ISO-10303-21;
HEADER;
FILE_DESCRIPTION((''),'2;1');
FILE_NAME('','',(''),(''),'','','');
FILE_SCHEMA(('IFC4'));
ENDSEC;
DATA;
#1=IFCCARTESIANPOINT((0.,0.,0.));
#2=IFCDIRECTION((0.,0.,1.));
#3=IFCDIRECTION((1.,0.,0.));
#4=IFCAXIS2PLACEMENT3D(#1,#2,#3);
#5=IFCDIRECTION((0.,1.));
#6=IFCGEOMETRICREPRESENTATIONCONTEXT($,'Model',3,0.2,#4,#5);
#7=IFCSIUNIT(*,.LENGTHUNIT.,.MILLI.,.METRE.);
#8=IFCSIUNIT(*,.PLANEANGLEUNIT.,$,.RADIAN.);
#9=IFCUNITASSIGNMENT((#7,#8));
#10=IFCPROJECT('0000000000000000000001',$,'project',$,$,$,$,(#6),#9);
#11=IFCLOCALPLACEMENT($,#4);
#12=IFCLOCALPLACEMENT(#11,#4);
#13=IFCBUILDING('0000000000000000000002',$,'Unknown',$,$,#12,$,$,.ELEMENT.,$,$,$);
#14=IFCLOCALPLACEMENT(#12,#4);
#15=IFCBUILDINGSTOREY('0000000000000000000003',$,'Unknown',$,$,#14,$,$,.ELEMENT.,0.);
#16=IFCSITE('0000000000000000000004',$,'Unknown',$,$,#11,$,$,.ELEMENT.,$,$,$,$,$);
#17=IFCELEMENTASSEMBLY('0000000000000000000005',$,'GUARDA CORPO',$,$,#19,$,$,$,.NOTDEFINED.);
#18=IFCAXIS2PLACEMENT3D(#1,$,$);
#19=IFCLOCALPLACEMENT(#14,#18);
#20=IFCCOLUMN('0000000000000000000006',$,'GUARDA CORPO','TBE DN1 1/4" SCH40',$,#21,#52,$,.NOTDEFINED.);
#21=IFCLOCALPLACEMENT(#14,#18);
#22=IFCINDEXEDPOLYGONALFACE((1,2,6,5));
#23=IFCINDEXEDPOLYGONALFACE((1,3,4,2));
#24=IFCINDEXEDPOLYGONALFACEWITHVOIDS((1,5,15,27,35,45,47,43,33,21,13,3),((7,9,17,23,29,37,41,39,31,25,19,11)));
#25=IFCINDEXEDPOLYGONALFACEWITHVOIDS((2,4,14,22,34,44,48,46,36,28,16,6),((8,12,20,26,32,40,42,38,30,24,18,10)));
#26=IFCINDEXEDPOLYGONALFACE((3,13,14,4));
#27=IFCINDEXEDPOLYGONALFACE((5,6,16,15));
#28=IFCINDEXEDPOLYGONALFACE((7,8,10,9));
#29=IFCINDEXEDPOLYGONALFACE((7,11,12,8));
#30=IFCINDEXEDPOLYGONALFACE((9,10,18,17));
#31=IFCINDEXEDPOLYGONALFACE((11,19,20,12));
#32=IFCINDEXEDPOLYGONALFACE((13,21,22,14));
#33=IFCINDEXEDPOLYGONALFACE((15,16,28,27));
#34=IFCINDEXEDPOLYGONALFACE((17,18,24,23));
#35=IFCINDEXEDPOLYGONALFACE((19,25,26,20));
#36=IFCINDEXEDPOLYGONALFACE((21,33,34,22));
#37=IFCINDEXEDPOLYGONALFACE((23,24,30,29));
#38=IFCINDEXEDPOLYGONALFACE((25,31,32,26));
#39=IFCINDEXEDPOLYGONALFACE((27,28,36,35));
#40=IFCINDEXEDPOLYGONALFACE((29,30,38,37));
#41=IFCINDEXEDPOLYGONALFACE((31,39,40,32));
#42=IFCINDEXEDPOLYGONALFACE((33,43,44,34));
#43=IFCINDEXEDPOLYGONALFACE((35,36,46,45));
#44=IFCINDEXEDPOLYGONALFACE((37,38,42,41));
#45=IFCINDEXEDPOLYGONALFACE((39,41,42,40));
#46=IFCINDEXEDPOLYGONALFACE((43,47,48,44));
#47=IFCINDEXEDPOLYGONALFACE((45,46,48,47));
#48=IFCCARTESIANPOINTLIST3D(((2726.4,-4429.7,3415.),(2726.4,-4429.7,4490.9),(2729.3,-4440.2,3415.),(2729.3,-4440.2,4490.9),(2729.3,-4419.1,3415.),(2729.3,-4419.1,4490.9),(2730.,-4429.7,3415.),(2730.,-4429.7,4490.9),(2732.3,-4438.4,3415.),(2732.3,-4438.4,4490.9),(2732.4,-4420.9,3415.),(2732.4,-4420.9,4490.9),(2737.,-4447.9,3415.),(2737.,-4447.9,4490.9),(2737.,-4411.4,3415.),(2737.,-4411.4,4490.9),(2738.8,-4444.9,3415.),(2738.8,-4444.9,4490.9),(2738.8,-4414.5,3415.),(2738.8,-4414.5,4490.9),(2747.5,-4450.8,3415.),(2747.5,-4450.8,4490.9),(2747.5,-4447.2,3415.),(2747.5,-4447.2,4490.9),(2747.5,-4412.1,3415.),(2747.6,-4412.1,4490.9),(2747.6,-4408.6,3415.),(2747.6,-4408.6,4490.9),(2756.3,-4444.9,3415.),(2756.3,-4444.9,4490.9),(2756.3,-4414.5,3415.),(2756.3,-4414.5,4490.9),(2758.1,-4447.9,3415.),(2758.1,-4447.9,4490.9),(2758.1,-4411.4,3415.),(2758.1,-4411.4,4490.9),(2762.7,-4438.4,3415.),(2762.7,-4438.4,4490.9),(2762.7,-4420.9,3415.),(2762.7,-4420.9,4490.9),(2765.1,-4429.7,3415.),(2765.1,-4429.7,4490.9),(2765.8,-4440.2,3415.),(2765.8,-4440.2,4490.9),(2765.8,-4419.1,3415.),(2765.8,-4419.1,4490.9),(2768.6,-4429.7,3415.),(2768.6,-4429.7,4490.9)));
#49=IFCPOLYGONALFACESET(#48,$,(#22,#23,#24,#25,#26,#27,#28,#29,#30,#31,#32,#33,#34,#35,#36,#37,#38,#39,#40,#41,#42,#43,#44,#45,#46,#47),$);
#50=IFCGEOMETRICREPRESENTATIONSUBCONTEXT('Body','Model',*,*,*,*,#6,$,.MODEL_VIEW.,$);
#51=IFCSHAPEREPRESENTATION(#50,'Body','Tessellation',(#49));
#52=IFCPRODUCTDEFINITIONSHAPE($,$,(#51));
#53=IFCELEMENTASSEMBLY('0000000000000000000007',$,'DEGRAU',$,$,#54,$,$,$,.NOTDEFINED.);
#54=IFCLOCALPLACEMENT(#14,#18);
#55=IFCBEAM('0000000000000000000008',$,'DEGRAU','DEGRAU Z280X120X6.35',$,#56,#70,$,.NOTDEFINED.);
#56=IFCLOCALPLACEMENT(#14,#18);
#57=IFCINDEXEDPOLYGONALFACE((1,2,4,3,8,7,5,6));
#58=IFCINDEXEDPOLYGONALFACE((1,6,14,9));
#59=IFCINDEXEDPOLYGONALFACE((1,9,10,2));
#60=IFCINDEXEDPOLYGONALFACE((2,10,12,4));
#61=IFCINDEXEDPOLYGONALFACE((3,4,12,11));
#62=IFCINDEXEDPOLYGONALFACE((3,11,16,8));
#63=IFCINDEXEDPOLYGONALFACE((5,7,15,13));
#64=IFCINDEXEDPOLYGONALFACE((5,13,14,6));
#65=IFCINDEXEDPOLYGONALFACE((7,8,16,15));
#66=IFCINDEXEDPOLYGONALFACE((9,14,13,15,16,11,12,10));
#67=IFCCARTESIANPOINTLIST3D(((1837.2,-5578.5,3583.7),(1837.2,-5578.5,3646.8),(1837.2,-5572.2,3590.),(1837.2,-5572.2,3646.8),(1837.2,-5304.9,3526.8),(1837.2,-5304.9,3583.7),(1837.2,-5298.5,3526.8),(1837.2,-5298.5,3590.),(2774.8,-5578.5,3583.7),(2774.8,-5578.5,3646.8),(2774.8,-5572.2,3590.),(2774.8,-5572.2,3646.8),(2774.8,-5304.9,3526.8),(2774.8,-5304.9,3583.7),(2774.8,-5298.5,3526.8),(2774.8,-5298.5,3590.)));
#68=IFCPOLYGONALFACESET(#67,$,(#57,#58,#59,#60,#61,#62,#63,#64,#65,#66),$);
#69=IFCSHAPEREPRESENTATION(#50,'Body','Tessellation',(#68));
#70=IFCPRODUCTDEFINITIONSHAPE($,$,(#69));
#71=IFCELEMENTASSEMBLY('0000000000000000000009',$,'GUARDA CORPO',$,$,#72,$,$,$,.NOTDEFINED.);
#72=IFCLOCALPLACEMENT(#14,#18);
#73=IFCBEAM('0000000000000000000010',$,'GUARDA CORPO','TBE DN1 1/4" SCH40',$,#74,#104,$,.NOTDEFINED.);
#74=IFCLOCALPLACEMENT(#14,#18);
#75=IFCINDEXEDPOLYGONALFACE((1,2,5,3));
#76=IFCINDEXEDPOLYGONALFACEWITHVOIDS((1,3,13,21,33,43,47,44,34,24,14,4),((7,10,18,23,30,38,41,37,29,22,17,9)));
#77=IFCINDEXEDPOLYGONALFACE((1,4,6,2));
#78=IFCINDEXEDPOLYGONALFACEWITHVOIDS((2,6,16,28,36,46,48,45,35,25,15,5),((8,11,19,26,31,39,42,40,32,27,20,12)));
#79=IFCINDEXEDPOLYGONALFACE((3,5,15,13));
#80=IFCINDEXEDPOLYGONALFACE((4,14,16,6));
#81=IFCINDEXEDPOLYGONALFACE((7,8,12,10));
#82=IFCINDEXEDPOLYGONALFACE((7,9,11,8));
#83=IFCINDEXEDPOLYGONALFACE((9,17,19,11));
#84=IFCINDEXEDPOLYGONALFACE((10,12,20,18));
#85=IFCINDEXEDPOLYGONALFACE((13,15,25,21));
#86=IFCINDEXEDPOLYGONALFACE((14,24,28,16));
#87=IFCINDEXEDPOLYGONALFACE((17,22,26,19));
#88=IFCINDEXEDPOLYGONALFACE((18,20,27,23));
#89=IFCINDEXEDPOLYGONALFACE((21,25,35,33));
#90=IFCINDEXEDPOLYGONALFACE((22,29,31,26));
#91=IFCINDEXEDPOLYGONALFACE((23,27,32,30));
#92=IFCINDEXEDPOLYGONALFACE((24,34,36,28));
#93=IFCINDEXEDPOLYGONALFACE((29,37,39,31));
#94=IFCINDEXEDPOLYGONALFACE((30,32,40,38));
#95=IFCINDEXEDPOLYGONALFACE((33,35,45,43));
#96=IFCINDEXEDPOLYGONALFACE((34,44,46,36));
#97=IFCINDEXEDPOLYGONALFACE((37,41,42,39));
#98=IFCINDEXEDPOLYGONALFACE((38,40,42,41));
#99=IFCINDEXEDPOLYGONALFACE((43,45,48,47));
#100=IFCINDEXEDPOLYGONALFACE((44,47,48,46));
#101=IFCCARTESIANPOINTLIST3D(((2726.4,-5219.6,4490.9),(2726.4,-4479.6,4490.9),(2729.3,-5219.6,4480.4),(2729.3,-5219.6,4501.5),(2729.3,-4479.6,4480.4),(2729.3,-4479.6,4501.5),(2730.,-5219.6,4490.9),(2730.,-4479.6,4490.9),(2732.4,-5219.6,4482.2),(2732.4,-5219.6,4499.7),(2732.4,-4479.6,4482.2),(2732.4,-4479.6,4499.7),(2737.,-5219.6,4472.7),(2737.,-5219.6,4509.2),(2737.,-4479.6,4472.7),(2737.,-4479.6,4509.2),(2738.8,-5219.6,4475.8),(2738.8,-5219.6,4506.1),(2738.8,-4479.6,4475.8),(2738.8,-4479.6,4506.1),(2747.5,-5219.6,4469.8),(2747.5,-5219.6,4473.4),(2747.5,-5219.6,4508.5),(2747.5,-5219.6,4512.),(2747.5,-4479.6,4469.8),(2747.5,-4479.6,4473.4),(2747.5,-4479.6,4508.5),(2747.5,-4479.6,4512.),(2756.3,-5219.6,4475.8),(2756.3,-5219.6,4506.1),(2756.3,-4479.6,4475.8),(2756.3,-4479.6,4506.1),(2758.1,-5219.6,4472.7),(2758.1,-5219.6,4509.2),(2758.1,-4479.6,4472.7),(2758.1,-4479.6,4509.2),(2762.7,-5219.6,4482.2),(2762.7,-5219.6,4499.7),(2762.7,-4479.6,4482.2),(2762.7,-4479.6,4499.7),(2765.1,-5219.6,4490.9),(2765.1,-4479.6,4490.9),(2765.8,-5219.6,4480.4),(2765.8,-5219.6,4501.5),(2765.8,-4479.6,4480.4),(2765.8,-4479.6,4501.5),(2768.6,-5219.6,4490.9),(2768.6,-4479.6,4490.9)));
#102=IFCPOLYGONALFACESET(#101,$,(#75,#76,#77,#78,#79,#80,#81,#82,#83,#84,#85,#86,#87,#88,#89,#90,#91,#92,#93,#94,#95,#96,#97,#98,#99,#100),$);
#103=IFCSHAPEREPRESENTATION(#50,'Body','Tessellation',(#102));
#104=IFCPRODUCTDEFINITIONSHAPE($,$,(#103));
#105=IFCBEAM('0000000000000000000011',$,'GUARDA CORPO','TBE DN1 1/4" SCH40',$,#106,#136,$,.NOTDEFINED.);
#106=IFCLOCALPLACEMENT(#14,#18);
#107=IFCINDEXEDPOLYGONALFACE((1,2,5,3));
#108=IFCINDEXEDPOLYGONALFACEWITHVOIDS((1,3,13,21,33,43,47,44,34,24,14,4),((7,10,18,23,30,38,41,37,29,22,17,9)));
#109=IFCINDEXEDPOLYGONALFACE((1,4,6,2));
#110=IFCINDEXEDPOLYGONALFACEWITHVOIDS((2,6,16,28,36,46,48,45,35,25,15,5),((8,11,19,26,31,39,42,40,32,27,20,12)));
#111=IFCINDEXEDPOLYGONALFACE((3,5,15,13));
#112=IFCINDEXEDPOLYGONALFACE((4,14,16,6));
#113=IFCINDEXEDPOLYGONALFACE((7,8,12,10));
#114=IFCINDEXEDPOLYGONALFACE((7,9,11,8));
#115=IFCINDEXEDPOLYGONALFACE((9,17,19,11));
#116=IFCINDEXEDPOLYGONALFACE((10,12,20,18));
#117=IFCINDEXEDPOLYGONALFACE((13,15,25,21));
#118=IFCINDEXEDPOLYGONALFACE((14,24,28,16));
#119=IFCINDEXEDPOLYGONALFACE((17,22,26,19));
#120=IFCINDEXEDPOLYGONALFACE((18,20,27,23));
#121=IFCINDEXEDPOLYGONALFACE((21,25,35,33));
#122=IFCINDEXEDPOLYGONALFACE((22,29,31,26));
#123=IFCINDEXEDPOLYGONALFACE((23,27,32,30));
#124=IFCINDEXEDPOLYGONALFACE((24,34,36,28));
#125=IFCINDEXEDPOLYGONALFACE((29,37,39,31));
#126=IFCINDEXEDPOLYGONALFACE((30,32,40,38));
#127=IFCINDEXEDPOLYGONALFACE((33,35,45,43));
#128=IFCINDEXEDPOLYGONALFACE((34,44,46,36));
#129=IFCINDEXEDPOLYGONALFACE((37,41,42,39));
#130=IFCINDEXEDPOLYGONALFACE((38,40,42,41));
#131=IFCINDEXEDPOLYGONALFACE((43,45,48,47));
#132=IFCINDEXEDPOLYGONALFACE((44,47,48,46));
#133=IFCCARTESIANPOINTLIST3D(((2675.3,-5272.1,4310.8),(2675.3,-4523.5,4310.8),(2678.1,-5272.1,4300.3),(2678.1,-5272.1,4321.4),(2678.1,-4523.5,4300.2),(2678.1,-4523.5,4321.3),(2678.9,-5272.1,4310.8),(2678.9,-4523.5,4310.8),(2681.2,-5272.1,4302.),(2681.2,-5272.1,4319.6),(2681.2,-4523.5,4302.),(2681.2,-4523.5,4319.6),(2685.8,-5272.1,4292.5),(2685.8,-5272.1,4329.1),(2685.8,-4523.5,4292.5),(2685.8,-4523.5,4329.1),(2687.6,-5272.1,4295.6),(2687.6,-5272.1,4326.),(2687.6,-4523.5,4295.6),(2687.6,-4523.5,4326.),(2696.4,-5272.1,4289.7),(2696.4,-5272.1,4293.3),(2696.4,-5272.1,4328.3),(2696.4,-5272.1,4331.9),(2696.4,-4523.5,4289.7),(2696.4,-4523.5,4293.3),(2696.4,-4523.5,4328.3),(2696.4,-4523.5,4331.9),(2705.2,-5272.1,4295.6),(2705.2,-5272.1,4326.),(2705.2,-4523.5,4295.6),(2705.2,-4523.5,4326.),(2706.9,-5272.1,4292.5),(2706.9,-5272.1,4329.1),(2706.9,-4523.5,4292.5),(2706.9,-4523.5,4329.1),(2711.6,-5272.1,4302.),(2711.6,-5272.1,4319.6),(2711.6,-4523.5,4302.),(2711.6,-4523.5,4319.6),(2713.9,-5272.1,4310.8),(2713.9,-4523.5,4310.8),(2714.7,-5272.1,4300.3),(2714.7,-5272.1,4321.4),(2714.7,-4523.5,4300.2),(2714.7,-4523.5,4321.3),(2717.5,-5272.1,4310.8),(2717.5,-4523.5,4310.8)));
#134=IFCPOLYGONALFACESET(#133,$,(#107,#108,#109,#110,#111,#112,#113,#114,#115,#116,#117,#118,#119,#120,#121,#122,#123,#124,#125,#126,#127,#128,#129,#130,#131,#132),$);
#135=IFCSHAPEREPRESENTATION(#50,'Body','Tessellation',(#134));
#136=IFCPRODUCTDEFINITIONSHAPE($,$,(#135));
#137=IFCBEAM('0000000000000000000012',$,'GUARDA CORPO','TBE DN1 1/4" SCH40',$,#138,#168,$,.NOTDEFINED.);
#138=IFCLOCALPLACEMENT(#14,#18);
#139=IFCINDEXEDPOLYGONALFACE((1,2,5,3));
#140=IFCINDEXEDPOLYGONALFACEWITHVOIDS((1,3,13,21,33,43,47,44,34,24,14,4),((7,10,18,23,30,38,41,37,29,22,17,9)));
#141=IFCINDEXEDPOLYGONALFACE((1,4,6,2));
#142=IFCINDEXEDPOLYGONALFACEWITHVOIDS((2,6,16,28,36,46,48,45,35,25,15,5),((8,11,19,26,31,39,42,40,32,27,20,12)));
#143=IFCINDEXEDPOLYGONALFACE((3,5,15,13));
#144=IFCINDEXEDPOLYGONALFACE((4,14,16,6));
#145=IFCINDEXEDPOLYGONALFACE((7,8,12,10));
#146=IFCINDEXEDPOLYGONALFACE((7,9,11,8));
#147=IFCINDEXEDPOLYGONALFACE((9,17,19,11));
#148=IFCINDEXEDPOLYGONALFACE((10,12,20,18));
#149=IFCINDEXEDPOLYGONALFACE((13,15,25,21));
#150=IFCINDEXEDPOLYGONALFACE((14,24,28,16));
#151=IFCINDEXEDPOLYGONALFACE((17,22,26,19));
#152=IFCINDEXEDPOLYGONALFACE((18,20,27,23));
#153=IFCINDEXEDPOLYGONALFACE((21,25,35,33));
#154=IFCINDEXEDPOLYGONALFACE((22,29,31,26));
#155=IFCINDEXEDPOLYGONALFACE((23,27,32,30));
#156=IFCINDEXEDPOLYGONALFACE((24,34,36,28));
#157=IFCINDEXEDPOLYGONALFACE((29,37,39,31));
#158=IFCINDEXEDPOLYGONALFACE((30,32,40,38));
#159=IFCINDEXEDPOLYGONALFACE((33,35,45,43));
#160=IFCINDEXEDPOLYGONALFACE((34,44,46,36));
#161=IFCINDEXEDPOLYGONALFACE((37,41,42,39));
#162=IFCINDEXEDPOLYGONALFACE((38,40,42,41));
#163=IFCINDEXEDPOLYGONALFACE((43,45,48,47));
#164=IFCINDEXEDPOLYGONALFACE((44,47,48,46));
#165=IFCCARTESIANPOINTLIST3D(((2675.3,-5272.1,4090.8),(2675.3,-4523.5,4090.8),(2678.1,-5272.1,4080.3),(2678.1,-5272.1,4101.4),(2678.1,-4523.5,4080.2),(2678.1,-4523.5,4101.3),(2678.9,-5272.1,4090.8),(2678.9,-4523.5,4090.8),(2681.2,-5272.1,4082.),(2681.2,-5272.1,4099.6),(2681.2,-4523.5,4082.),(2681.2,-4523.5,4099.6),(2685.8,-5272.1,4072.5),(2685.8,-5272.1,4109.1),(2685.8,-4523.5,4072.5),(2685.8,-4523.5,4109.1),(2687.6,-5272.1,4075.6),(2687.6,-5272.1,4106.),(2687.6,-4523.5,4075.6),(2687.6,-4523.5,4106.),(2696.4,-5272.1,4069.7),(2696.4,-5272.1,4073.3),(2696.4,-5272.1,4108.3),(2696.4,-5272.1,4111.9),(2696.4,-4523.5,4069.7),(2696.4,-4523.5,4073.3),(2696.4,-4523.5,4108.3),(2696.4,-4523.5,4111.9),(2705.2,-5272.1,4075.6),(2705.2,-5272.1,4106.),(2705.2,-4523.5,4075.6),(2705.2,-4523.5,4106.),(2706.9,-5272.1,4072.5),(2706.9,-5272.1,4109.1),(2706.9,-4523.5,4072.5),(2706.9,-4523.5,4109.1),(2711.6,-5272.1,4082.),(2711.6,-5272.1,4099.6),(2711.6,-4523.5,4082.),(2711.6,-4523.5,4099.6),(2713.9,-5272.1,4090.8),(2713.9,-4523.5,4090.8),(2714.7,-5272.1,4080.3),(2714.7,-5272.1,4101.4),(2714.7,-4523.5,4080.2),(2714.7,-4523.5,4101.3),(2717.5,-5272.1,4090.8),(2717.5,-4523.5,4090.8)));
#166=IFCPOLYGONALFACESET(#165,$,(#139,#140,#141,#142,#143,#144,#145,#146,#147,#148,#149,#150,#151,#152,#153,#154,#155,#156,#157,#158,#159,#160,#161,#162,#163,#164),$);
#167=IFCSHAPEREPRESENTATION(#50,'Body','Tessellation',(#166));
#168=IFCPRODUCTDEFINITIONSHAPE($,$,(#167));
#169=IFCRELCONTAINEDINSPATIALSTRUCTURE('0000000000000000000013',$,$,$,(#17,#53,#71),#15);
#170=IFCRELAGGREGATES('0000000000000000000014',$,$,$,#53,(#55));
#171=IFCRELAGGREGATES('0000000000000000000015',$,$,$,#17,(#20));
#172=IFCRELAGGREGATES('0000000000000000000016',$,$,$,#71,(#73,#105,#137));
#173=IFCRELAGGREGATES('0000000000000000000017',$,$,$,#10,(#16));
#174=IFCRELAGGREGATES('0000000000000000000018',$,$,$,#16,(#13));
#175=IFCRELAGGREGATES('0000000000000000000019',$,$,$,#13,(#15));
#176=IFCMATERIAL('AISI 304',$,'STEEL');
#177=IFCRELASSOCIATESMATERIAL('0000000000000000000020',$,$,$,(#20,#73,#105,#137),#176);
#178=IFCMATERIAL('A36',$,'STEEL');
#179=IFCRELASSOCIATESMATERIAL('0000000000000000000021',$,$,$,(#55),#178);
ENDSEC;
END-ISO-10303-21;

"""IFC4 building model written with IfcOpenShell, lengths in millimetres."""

from ifc_helpers import new_model, si_unit, direction, frame, origin_with_axes, place, context, subcontext, project, spatial, line, indexed_curve, outline, extrude, material, element, aggregate, save


model = new_model("IFC4")

# Units and contexts
model_context = context("Model", 3, precision=0.2, world=origin_with_axes(), true_north=direction((0.0, 1.0)))
body_context = subcontext(model_context, "Body", "Model", "MODEL_VIEW")
ifc_project = project(units=[si_unit("LENGTHUNIT", "METRE", prefix="MILLI"), si_unit("PLANEANGLEUNIT", "RADIAN")], contexts=[model_context])

# Site, building, storey
site_placement = place(None, origin_with_axes())
site = spatial("IfcSite", under=ifc_project, at=site_placement, Name="Unknown", CompositionType="ELEMENT")
building_placement = place(site_placement, origin_with_axes())
building = spatial("IfcBuilding", under=site, at=building_placement, Name="Unknown", CompositionType="ELEMENT")
storey_placement = place(building_placement, origin_with_axes())
storey = spatial("IfcBuildingStorey", under=building, at=storey_placement, Name="Unknown", CompositionType="ELEMENT", Elevation=0.0)

# Element assembly, column
assembly_1_placement = place(storey_placement, frame((2747.5, -4429.7, 3415.0), z_axis=(-0.000512, -1.0, -0.000003), x_axis=(0.000003, -0.000003, 1.0)))
assembly_1 = element("IfcElementAssembly", 1, at=assembly_1_placement, inside=storey, Name="GUARDA CORPO", PredefinedType="NOTDEFINED")
ifc_material_1 = material(Name="AISI 304", Category="STEEL")
column_placement = place(assembly_1_placement, origin_with_axes())
column = element("IfcColumn", 2, at=column_placement, material=ifc_material_1, Name="GUARDA CORPO", Description="TBE DN1 1/4\" SCH40", PredefinedType="NOTDEFINED", context=body_context, shape_type="SolidModel", body=[
    extrude(outline(indexed_curve([(21.1, 0.0), (18.3, 10.6), (10.6, 18.3), (0.0, 21.1), (-10.6, 18.3), (-18.3, 10.6), (-21.1, 0.0), (-18.3, -10.6), (-10.6, -18.3), (0.0, -21.1), (10.6, -18.3), (18.3, -10.6)], segments=[line(1, 2, 3, 4, 5, 6, 7, 8, 9, 10, 11, 12, 1)]), holes=[indexed_curve([(17.5, 0.0), (15.2, -8.8), (8.8, -15.2), (0.0, -17.5), (-8.8, -15.2), (-15.2, -8.8), (-17.5, 0.0), (-15.2, 8.8), (-8.8, 15.2), (0.0, 17.5), (8.8, 15.2), (15.2, 8.8)], segments=[line(1, 2, 3, 4, 5, 6, 7, 8, 9, 10, 11, 12, 1)])]), frame((0.0, 0.0, 0.0), z_axis=(-1.0, 0.0, 0.0), x_axis=(0.0, 0.0, 1.0)), (0.0, 0.0, -1.0), 1075.9),
])

# Shared definitions
ifc_material_2 = material(Name="A36", Category="STEEL")

# Element assembly, beam
assembly_2_placement = place(storey_placement, frame((1837.2, -5438.5, 3586.8), z_axis=(0.0, 0.0, 1.0), x_axis=(1.0, 0.0, 0.0)))
assembly_2 = element("IfcElementAssembly", 3, at=assembly_2_placement, inside=storey, Name="DEGRAU", PredefinedType="NOTDEFINED")
beam_1_placement = place(assembly_2_placement, origin_with_axes())
beam_1 = element("IfcBeam", 4, at=beam_1_placement, material=ifc_material_2, Name="DEGRAU", Description="DEGRAU Z280X120X6.35", PredefinedType="NOTDEFINED", context=body_context, shape_type="SolidModel", body=[
    extrude(outline(indexed_curve([(-3.2, -140.0), (60.0, -140.0), (60.0, -133.7), (3.2, -133.7), (3.2, 140.0), (-60.0, 140.0), (-60.0, 133.7), (-3.2, 133.7)], segments=[line(1, 2, 3, 4, 5, 6, 7, 8, 1)])), frame((0.0, 0.0, 0.0), z_axis=(-1.0, 0.0, 0.0), x_axis=(0.0, 0.0, 1.0)), (0.0, 0.0, -1.0), 937.5),
])
aggregate(assembly_2, [beam_1])

# Element assembly, beams
assembly_3_placement = place(storey_placement, frame((2747.5, -5087.8, 3415.0), z_axis=(-1.0, 0.000512, 0.000003), x_axis=(0.000003, 0.000003, 1.0)))
assembly_3 = element("IfcElementAssembly", 5, at=assembly_3_placement, inside=storey, Name="GUARDA CORPO", PredefinedType="NOTDEFINED")
beam_2_placement = place(assembly_3_placement, frame((1075.9, 608.1, 0.3), z_axis=(-0.000003, 0.000512, -1.0), x_axis=(0.000003, -1.0, -0.000512)))
beam_2 = element("IfcBeam", 6, at=beam_2_placement, material=ifc_material_1, Name="GUARDA CORPO", Description="TBE DN1 1/4\" SCH40", PredefinedType="NOTDEFINED", context=body_context, shape_type="SolidModel", body=[
    extrude(outline(indexed_curve([(21.1, 0.0), (18.3, 10.6), (10.6, 18.3), (0.0, 21.1), (-10.6, 18.3), (-18.3, 10.6), (-21.1, 0.0), (-18.3, -10.6), (-10.6, -18.3), (0.0, -21.1), (10.6, -18.3), (18.3, -10.6)], segments=[line(1, 2, 3, 4, 5, 6, 7, 8, 9, 10, 11, 12, 1)]), holes=[indexed_curve([(17.5, 0.0), (15.2, -8.8), (8.8, -15.2), (0.0, -17.5), (-8.8, -15.2), (-15.2, -8.8), (-17.5, 0.0), (-15.2, 8.8), (-8.8, 15.2), (0.0, 17.5), (8.8, 15.2), (15.2, 8.8)], segments=[line(1, 2, 3, 4, 5, 6, 7, 8, 9, 10, 11, 12, 1)])]), frame((0.0, 0.0, 0.0), z_axis=(-1.0, 0.0, 0.0), x_axis=(0.0, 0.0, 1.0)), (0.0, 0.0, -1.0), 740.0),
])
beam_3_placement = place(assembly_3_placement, frame((895.8, 564.2, 51.4), z_axis=(-0.000003, 0.000512, -1.0), x_axis=(0.000004, -1.0, -0.000512)))
beam_3 = element("IfcBeam", 7, at=beam_3_placement, material=ifc_material_1, Name="GUARDA CORPO", Description="TBE DN1 1/4\" SCH40", PredefinedType="NOTDEFINED", context=body_context, shape_type="SolidModel", body=[
    extrude(outline(indexed_curve([(21.1, 0.0), (18.3, 10.6), (10.6, 18.3), (0.0, 21.1), (-10.6, 18.3), (-18.3, 10.6), (-21.1, 0.0), (-18.3, -10.6), (-10.6, -18.3), (0.0, -21.1), (10.6, -18.3), (18.3, -10.6)], segments=[line(1, 2, 3, 4, 5, 6, 7, 8, 9, 10, 11, 12, 1)]), holes=[indexed_curve([(17.5, 0.0), (15.2, -8.8), (8.8, -15.2), (0.0, -17.5), (-8.8, -15.2), (-15.2, -8.8), (-17.5, 0.0), (-15.2, 8.8), (-8.8, 15.2), (0.0, 17.5), (8.8, 15.2), (15.2, 8.8)], segments=[line(1, 2, 3, 4, 5, 6, 7, 8, 9, 10, 11, 12, 1)])]), frame((0.0, 0.0, 0.0), z_axis=(-1.0, 0.0, 0.0), x_axis=(0.0, 0.0, 1.0)), (0.0, 0.0, -1.0), 748.6),
])
beam_4_placement = place(assembly_3_placement, frame((675.8, 564.2, 51.4), z_axis=(-0.000003, 0.000512, -1.0), x_axis=(0.000004, -1.0, -0.000512)))
beam_4 = element("IfcBeam", 8, at=beam_4_placement, material=ifc_material_1, Name="GUARDA CORPO", Description="TBE DN1 1/4\" SCH40", PredefinedType="NOTDEFINED", context=body_context, shape_type="SolidModel", body=[
    extrude(outline(indexed_curve([(21.1, 0.0), (18.3, 10.6), (10.6, 18.3), (0.0, 21.1), (-10.6, 18.3), (-18.3, 10.6), (-21.1, 0.0), (-18.3, -10.6), (-10.6, -18.3), (0.0, -21.1), (10.6, -18.3), (18.3, -10.6)], segments=[line(1, 2, 3, 4, 5, 6, 7, 8, 9, 10, 11, 12, 1)]), holes=[indexed_curve([(17.5, 0.0), (15.2, -8.8), (8.8, -15.2), (0.0, -17.5), (-8.8, -15.2), (-15.2, -8.8), (-17.5, 0.0), (-15.2, 8.8), (-8.8, 15.2), (0.0, 17.5), (8.8, 15.2), (15.2, 8.8)], segments=[line(1, 2, 3, 4, 5, 6, 7, 8, 9, 10, 11, 12, 1)])]), frame((0.0, 0.0, 0.0), z_axis=(-1.0, 0.0, 0.0), x_axis=(0.0, 0.0, 1.0)), (0.0, 0.0, -1.0), 748.5),
])

aggregate(assembly_1, [column])
aggregate(assembly_3, [beam_2, beam_3, beam_4])

save(model, "model.ifc")
